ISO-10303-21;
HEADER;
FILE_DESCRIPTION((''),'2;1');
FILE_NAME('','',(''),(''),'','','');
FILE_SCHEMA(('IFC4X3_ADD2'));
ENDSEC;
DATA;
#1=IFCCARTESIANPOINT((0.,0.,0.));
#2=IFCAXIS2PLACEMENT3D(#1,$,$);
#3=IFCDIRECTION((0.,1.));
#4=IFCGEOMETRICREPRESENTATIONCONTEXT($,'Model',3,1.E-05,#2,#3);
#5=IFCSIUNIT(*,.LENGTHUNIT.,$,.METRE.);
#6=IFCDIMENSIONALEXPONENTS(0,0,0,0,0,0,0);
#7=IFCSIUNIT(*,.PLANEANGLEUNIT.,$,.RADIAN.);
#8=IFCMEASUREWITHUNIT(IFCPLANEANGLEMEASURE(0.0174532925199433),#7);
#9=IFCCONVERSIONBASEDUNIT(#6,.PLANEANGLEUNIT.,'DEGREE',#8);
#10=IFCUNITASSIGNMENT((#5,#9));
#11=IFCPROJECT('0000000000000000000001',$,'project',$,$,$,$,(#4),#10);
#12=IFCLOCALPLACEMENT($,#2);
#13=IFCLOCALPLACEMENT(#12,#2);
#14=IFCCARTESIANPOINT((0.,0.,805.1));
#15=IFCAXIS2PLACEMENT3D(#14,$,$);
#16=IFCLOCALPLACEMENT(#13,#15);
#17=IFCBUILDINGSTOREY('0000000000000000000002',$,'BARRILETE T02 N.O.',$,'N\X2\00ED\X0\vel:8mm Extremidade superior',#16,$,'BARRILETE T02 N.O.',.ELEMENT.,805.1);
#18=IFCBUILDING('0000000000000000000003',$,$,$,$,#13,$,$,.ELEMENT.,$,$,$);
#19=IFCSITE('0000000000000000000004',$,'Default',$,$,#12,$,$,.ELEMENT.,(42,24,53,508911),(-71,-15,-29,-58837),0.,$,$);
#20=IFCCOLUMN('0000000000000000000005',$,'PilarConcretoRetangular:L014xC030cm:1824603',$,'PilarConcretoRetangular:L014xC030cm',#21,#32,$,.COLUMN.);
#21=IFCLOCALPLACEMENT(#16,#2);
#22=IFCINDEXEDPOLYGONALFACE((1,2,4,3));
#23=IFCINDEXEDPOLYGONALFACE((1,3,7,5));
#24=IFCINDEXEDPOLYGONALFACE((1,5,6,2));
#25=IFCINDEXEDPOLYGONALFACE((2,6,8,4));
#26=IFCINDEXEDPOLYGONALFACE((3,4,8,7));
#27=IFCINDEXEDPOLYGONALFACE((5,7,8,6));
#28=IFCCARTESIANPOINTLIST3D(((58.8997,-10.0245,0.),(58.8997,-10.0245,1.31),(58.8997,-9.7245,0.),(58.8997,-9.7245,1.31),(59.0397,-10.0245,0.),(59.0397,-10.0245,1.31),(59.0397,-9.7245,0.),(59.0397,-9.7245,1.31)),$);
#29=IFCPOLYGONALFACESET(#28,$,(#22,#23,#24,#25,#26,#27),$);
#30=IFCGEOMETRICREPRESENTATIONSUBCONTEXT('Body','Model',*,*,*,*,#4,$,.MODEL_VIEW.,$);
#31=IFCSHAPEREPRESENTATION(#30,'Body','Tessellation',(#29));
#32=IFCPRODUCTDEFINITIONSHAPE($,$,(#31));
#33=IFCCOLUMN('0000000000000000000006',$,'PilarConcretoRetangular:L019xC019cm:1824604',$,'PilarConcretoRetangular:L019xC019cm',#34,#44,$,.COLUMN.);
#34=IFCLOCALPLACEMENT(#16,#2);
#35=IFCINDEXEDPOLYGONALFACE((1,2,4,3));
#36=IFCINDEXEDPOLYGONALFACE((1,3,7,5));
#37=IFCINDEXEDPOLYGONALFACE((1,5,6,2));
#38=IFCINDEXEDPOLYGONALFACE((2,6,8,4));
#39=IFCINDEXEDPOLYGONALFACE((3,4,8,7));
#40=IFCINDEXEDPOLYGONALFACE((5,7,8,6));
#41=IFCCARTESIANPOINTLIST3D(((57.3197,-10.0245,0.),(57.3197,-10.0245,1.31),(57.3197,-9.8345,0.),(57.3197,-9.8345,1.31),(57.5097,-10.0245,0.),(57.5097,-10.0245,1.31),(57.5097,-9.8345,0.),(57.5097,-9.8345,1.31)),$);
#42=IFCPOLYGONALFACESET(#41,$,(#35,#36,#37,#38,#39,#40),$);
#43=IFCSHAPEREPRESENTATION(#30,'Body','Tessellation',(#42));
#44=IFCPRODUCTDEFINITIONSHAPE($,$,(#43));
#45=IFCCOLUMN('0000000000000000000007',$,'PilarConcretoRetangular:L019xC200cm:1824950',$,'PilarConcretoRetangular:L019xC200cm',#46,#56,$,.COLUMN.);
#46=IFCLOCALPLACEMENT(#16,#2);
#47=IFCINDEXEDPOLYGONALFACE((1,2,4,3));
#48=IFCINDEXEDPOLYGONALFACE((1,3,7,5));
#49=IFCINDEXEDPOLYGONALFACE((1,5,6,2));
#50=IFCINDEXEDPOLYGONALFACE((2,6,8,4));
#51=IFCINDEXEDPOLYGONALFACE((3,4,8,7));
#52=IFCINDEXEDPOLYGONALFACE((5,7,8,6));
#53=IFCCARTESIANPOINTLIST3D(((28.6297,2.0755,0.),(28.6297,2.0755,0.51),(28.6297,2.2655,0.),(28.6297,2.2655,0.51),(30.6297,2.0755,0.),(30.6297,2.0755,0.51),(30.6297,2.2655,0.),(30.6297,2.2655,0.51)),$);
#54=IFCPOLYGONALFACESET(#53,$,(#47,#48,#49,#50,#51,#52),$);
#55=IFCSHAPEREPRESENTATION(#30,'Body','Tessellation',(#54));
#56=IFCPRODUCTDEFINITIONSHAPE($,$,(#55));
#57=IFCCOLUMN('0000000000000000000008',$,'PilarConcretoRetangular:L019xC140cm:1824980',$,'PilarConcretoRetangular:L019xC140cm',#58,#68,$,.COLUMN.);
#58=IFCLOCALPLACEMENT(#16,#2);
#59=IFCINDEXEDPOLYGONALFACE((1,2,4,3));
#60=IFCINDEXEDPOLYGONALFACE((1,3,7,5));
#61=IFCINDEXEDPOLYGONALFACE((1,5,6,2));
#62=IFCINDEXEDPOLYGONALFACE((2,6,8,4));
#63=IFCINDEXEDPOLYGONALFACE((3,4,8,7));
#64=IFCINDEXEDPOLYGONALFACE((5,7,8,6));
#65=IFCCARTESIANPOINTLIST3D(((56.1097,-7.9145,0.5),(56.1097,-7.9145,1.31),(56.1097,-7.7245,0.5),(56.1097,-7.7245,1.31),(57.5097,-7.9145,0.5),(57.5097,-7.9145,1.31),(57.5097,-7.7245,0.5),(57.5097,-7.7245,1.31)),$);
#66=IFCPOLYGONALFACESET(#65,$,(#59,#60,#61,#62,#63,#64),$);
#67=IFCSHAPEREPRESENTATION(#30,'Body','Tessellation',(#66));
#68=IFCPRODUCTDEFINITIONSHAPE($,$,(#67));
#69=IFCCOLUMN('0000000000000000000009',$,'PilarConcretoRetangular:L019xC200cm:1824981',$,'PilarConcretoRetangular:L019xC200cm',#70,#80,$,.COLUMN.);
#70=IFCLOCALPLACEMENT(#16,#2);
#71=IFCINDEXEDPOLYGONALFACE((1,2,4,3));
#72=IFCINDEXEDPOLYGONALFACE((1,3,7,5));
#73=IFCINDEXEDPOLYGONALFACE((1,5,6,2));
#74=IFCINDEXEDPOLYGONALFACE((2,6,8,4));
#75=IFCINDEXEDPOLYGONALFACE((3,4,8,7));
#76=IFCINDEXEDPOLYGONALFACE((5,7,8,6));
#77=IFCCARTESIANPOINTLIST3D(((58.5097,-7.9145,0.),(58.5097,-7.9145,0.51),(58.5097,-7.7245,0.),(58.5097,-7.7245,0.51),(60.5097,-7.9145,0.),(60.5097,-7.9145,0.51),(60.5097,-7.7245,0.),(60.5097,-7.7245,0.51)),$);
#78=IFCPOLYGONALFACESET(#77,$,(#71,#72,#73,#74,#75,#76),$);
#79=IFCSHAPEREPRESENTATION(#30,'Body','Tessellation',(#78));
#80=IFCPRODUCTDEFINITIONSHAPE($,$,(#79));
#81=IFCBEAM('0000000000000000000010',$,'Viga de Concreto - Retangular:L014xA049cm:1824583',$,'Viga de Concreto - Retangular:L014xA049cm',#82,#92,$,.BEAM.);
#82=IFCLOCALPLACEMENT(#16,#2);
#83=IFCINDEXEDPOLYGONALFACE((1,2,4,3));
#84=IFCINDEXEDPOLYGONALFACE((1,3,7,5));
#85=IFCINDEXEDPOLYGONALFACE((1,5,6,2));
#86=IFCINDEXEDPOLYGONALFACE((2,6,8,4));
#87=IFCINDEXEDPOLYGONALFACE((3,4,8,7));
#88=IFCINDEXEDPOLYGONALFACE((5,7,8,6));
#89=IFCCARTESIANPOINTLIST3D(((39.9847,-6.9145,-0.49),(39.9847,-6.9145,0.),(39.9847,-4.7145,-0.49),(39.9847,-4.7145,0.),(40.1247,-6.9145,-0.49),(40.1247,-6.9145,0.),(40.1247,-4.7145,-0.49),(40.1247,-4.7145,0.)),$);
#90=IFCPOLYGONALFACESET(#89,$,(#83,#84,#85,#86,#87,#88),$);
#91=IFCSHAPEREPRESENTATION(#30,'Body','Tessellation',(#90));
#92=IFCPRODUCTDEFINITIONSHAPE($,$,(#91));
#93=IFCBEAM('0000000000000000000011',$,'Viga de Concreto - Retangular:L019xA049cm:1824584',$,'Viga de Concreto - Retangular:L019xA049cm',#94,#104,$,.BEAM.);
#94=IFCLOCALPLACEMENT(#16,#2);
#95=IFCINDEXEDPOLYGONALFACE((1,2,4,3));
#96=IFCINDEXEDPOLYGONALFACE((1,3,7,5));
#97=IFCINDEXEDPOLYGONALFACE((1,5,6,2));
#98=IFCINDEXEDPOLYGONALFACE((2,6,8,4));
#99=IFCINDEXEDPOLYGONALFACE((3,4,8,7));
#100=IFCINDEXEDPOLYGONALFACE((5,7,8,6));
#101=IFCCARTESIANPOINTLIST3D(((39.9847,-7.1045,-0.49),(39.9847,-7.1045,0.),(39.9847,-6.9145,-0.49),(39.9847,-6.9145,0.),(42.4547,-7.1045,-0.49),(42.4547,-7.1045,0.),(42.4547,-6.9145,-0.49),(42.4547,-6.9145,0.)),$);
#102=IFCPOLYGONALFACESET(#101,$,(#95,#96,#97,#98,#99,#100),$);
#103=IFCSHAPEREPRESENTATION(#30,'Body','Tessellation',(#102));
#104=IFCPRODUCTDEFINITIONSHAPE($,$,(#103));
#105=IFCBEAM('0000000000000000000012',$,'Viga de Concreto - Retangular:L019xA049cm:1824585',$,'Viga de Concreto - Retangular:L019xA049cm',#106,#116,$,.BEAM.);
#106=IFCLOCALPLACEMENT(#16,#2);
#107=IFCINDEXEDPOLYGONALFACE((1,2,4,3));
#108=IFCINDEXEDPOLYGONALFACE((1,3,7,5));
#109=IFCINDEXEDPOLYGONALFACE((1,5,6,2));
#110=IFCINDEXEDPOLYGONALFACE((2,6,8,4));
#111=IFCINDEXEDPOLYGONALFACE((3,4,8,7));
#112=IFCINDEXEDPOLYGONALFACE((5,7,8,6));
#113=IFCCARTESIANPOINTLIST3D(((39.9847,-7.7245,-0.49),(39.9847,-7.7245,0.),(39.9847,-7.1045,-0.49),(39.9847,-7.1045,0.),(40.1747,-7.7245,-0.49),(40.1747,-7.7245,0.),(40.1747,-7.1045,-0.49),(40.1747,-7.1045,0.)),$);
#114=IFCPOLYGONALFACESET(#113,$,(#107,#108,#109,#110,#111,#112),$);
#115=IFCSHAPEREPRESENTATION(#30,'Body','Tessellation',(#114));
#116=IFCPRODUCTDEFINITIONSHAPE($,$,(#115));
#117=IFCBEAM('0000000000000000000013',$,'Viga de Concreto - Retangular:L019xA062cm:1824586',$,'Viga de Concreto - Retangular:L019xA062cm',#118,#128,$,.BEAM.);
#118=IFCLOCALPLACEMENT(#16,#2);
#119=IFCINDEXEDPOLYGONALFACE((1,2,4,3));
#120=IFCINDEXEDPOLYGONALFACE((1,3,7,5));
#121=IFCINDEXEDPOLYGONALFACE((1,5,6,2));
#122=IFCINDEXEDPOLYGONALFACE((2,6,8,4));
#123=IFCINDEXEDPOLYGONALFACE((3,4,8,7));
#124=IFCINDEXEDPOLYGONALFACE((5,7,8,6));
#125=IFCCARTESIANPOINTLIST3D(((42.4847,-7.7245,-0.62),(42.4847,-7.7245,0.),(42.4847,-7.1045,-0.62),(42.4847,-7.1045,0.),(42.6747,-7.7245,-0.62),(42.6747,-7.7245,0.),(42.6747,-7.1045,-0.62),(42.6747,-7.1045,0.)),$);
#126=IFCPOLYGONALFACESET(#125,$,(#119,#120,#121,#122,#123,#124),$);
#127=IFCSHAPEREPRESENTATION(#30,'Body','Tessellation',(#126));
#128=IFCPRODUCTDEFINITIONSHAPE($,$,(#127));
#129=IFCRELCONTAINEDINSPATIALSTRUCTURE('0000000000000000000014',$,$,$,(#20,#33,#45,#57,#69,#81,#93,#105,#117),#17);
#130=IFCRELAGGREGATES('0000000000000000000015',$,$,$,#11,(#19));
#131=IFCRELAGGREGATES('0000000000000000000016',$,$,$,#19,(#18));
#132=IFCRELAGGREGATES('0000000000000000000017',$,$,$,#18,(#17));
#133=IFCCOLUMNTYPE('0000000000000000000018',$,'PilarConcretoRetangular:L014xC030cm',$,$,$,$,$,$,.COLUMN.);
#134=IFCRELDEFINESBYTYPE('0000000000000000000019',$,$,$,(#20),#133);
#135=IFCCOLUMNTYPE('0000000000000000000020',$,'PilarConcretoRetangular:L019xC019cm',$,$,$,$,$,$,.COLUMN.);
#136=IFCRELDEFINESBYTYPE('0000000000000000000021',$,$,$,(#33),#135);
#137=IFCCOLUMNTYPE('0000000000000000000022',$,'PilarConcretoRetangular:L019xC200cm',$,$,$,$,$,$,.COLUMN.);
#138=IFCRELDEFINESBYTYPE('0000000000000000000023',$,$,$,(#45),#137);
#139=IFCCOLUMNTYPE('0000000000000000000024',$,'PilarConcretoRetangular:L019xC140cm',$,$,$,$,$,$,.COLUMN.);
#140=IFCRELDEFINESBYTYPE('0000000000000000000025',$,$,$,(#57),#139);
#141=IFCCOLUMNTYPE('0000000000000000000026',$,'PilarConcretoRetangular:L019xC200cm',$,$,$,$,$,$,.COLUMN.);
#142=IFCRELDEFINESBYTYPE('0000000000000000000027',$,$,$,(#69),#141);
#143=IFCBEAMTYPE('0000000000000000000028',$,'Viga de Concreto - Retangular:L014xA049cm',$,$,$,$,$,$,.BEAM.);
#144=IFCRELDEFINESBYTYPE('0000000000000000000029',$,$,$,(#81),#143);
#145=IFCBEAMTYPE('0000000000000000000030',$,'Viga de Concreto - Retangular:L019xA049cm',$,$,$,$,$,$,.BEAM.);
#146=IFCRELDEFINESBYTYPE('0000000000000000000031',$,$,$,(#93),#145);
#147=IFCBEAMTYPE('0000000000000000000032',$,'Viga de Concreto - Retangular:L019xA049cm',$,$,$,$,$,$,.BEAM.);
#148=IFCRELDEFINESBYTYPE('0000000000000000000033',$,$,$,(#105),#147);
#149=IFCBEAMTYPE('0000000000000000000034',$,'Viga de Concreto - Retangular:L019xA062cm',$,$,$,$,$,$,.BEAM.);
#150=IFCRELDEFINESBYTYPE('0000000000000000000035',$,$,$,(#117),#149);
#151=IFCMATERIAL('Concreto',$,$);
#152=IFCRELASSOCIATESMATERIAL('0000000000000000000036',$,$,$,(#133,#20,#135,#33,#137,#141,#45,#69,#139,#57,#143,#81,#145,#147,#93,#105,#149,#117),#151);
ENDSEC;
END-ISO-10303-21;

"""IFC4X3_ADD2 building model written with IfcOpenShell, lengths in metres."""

from ifc_helpers import new_model, entity, si_unit, converted_unit, direction, frame, frame_2d, origin, origin_2d_with_axis, place, context, subcontext, project, spatial, rectangle, extrude, source, transform, mapped, material, material_profile, profile_set, profile_usage, type_object, type_shapes, element, save


model = new_model("IFC4X3_ADD2")

# Units and contexts
model_context = context("Model", 3, precision=1e-05, world=origin(), true_north=direction((0.0, 1.0)))
body_context = subcontext(model_context, "Body", "Model", "MODEL_VIEW")
ifc_project = project(units=[si_unit("LENGTHUNIT", "METRE"), converted_unit("PLANEANGLEUNIT", "DEGREE", entity("IfcPlaneAngleMeasure", 0.0174532925199433), si_unit("PLANEANGLEUNIT", "RADIAN"), dimensions=[0, 0, 0, 0, 0, 0, 0])], contexts=[model_context])

# Site, building, storey
site_placement = place(None, origin())
site = spatial("IfcSite", under=ifc_project, at=site_placement, Name="Default", CompositionType="ELEMENT", RefLatitude=(42, 24, 53, 508911), RefLongitude=(-71, -15, -29, -58837), RefElevation=0.0)
building_placement = place(site_placement, origin())
building = spatial("IfcBuilding", under=site, at=building_placement, CompositionType="ELEMENT")
storey_placement = place(building_placement, frame((0.0, 0.0, 805.1)))
storey = spatial("IfcBuildingStorey", under=building, at=storey_placement, Name="BARRILETE T02 N.O.", ObjectType="Nível:8mm Extremidade superior", LongName="BARRILETE T02 N.O.", CompositionType="ELEMENT", Elevation=805.1)

# Columns
ifc_material = material(Name="Concreto")
ifc_material_profile_1 = material_profile(ifc_material, rectangle(XDim=0.14, YDim=0.3, at=frame_2d((0.0, 0.0), x_axis=(1.0, 0.0))), Name="L014xC030cm")
ifc_profile_set_1 = profile_set([ifc_material_profile_1], Name="L014xC030cm")
ifc_profile_usage_1 = profile_usage(ifc_profile_set_1)
column_type_1 = type_object("IfcColumnType", Name="PilarConcretoRetangular:L014xC030cm", PredefinedType="COLUMN", material=ifc_profile_set_1)
shared_shape_1 = source(origin(), body_context, "Body", "SweptSolid", [
    extrude(rectangle(XDim=0.14, YDim=0.3, at=frame_2d((0.0, 0.0), x_axis=(1.0, 0.0))), frame((58.9697, -9.8745, 805.1), z_axis=(0.0, 0.0, 1.0), x_axis=(-1.0, 0.0, 0.0)), (0.0, 0.0, 1.0), 1.31),
])
type_shapes(column_type_1, [shared_shape_1])
column_1_placement = place(storey_placement, frame((0.0, 0.0, -805.1)))
element("IfcColumn", 1, at=column_1_placement, inside=storey, type_object=column_type_1, material=ifc_profile_usage_1, Name="PilarConcretoRetangular:L014xC030cm:1824603", ObjectType="PilarConcretoRetangular:L014xC030cm", PredefinedType="COLUMN", context=body_context, shape_type="MappedRepresentation", body=[
    mapped(shared_shape_1, transform((0.0, 0.0, 0.0), scale=1.0)),
])
ifc_material_profile_2 = material_profile(ifc_material, rectangle(XDim=0.19, YDim=0.19, at=frame_2d((0.0, 0.0), x_axis=(1.0, 0.0))), Name="L019xC019cm")
ifc_profile_set_2 = profile_set([ifc_material_profile_2], Name="L019xC019cm")
ifc_profile_usage_2 = profile_usage(ifc_profile_set_2)
column_type_2 = type_object("IfcColumnType", Name="PilarConcretoRetangular:L019xC019cm", PredefinedType="COLUMN", material=ifc_profile_set_2)
shared_shape_2 = source(origin(), body_context, "Body", "SweptSolid", [
    extrude(rectangle(XDim=0.19, YDim=0.19, at=frame_2d((0.0, 0.0), x_axis=(1.0, 0.0))), frame((57.4147, -9.9295, 805.1), z_axis=(0.0, 0.0, 1.0), x_axis=(0.0, 1.0, 0.0)), (0.0, 0.0, 1.0), 1.31),
])
type_shapes(column_type_2, [shared_shape_2])
column_2_placement = place(storey_placement, frame((0.0, 0.0, -805.1)))
element("IfcColumn", 2, at=column_2_placement, inside=storey, type_object=column_type_2, material=ifc_profile_usage_2, Name="PilarConcretoRetangular:L019xC019cm:1824604", ObjectType="PilarConcretoRetangular:L019xC019cm", PredefinedType="COLUMN", context=body_context, shape_type="MappedRepresentation", body=[
    mapped(shared_shape_2, transform((0.0, 0.0, 0.0), scale=1.0)),
])
ifc_material_profile_3 = material_profile(ifc_material, rectangle(XDim=0.19, YDim=2.0, at=frame_2d((0.0, 0.0), x_axis=(1.0, 0.0))), Name="L019xC200cm")
ifc_profile_set_3 = profile_set([ifc_material_profile_3], Name="L019xC200cm")
ifc_profile_usage_3 = profile_usage(ifc_profile_set_3)
column_type_3 = type_object("IfcColumnType", Name="PilarConcretoRetangular:L019xC200cm", PredefinedType="COLUMN", material=ifc_profile_set_3)
shared_shape_3 = source(origin(), body_context, "Body", "SweptSolid", [
    extrude(rectangle(XDim=0.19, YDim=2.0, at=frame_2d((0.0, 0.0), x_axis=(1.0, 0.0))), frame((29.6297, 2.1705, 805.1), z_axis=(0.0, 0.0, 1.0), x_axis=(0.0, 1.0, 0.0)), (0.0, 0.0, 1.0), 0.51),
])
type_shapes(column_type_3, [shared_shape_3])
column_3_placement = place(storey_placement, frame((0.0, 0.0, -805.1)))
element("IfcColumn", 3, at=column_3_placement, inside=storey, type_object=column_type_3, material=ifc_profile_usage_3, Name="PilarConcretoRetangular:L019xC200cm:1824950", ObjectType="PilarConcretoRetangular:L019xC200cm", PredefinedType="COLUMN", context=body_context, shape_type="MappedRepresentation", body=[
    mapped(shared_shape_3, transform((0.0, 0.0, 0.0), scale=1.0)),
])
ifc_material_profile_4 = material_profile(ifc_material, rectangle(XDim=0.19, YDim=1.4, at=origin_2d_with_axis()), Name="L019xC140cm")
ifc_profile_set_4 = profile_set([ifc_material_profile_4], Name="L019xC140cm")
ifc_profile_usage_4 = profile_usage(ifc_profile_set_4)
column_type_4 = type_object("IfcColumnType", Name="PilarConcretoRetangular:L019xC140cm", PredefinedType="COLUMN", material=ifc_profile_set_4)
shared_shape_4 = source(origin(), body_context, "Body", "SweptSolid", [
    extrude(rectangle(XDim=0.19, YDim=1.4, at=origin_2d_with_axis()), frame((56.8097, -7.8195, 805.6), z_axis=(0.0, 0.0, 1.0), x_axis=(0.0, -1.0, 0.0)), (0.0, 0.0, 1.0), 0.81),
])
type_shapes(column_type_4, [shared_shape_4])
column_4_placement = place(storey_placement, frame((0.0, 0.0, -805.1)))
element("IfcColumn", 4, at=column_4_placement, inside=storey, type_object=column_type_4, material=ifc_profile_usage_4, Name="PilarConcretoRetangular:L019xC140cm:1824980", ObjectType="PilarConcretoRetangular:L019xC140cm", PredefinedType="COLUMN", context=body_context, shape_type="MappedRepresentation", body=[
    mapped(shared_shape_4, transform((0.0, 0.0, 0.0), scale=1.0)),
])
column_type_5 = type_object("IfcColumnType", Name="PilarConcretoRetangular:L019xC200cm", PredefinedType="COLUMN", material=ifc_profile_set_3)
shared_shape_5 = source(origin(), body_context, "Body", "SweptSolid", [
    extrude(rectangle(XDim=2.0, YDim=0.19, at=frame_2d((0.0, 0.0), x_axis=(1.0, 0.0))), frame((59.5097, -7.8195, 805.1), z_axis=(0.0, 0.0, 1.0), x_axis=(-1.0, 0.0, 0.0)), (0.0, 0.0, 1.0), 0.51),
])
type_shapes(column_type_5, [shared_shape_5])
column_5_placement = place(storey_placement, frame((0.0, 0.0, -805.1)))
element("IfcColumn", 5, at=column_5_placement, inside=storey, type_object=column_type_5, material=ifc_profile_usage_3, Name="PilarConcretoRetangular:L019xC200cm:1824981", ObjectType="PilarConcretoRetangular:L019xC200cm", PredefinedType="COLUMN", context=body_context, shape_type="MappedRepresentation", body=[
    mapped(shared_shape_5, transform((0.0, 0.0, 0.0), scale=1.0)),
])

# Beams
ifc_material_profile_5 = material_profile(ifc_material, rectangle(XDim=0.62, YDim=0.19, at=frame_2d((0.0, 0.0), x_axis=(0.0, 1.0))), Name="L019xA062cm")
ifc_profile_set_5 = profile_set([ifc_material_profile_5], Name="L019xA062cm")
ifc_material_profile_6 = material_profile(ifc_material, rectangle(XDim=0.49, YDim=0.14, at=frame_2d((0.0, 0.0), x_axis=(0.0, 1.0))), Name="L014xA049cm")
ifc_profile_set_6 = profile_set([ifc_material_profile_6], Name="L014xA049cm")
ifc_profile_usage_5 = profile_usage(ifc_profile_set_6, cardinal=8)
beam_type_1 = type_object("IfcBeamType", Name="Viga de Concreto - Retangular:L014xA049cm", PredefinedType="BEAM", material=ifc_profile_set_6)
shared_shape_6 = source(origin(), body_context, "Body", "SweptSolid", [
    extrude(rectangle(XDim=0.49, YDim=0.14, at=frame_2d((0.0, 0.0), x_axis=(0.0, 1.0))), frame((40.0547, -4.7145, 804.855), z_axis=(0.0, -1.0, 0.0), x_axis=(-1.0, 0.0, 0.0)), (0.0, 0.0, 1.0), 2.2),
])
type_shapes(beam_type_1, [shared_shape_6])
beam_1_placement = place(storey_placement, frame((0.0, 0.0, -805.1)))
element("IfcBeam", 6, at=beam_1_placement, inside=storey, type_object=beam_type_1, material=ifc_profile_usage_5, Name="Viga de Concreto - Retangular:L014xA049cm:1824583", ObjectType="Viga de Concreto - Retangular:L014xA049cm", PredefinedType="BEAM", context=body_context, shape_type="MappedRepresentation", body=[
    mapped(shared_shape_6, transform((0.0, 0.0, 0.0), scale=1.0)),
])
ifc_material_profile_7 = material_profile(ifc_material, rectangle(XDim=0.49, YDim=0.19, at=frame_2d((0.0, 0.0), x_axis=(1.0, 0.0))), Name="L019xA049cm")
ifc_profile_set_7 = profile_set([ifc_material_profile_7], Name="L019xA049cm")
ifc_profile_usage_6 = profile_usage(ifc_profile_set_7, cardinal=8)
beam_type_2 = type_object("IfcBeamType", Name="Viga de Concreto - Retangular:L019xA049cm", PredefinedType="BEAM", material=ifc_profile_set_7)
shared_shape_7 = source(origin(), body_context, "Body", "SweptSolid", [
    extrude(rectangle(XDim=0.49, YDim=0.19, at=frame_2d((0.0, 0.0), x_axis=(1.0, 0.0))), frame((42.4547, -7.0095, 804.855), z_axis=(-1.0, 0.0, 0.0), x_axis=(0.0, 0.0, -1.0)), (0.0, 0.0, 1.0), 2.47),
])
type_shapes(beam_type_2, [shared_shape_7])
beam_2_placement = place(storey_placement, frame((0.0, 0.0, -805.1)))
element("IfcBeam", 7, at=beam_2_placement, inside=storey, type_object=beam_type_2, material=ifc_profile_usage_6, Name="Viga de Concreto - Retangular:L019xA049cm:1824584", ObjectType="Viga de Concreto - Retangular:L019xA049cm", PredefinedType="BEAM", context=body_context, shape_type="MappedRepresentation", body=[
    mapped(shared_shape_7, transform((0.0, 0.0, 0.0), scale=1.0)),
])
beam_type_3 = type_object("IfcBeamType", Name="Viga de Concreto - Retangular:L019xA049cm", PredefinedType="BEAM", material=ifc_profile_set_7)
shared_shape_8 = source(origin(), body_context, "Body", "SweptSolid", [
    extrude(rectangle(XDim=0.49, YDim=0.19, at=frame_2d((0.0, 0.0), x_axis=(0.0, 1.0))), frame((40.0797, -7.7245, 804.855), z_axis=(0.0, 1.0, 0.0), x_axis=(-1.0, 0.0, 0.0)), (0.0, 0.0, 1.0), 0.62),
])
type_shapes(beam_type_3, [shared_shape_8])
beam_3_placement = place(storey_placement, frame((0.0, 0.0, -805.1)))
element("IfcBeam", 8, at=beam_3_placement, inside=storey, type_object=beam_type_3, material=ifc_profile_usage_6, Name="Viga de Concreto - Retangular:L019xA049cm:1824585", ObjectType="Viga de Concreto - Retangular:L019xA049cm", PredefinedType="BEAM", context=body_context, shape_type="MappedRepresentation", body=[
    mapped(shared_shape_8, transform((0.0, 0.0, 0.0), scale=1.0)),
])
ifc_profile_usage_7 = profile_usage(ifc_profile_set_5, cardinal=8)
beam_type_4 = type_object("IfcBeamType", Name="Viga de Concreto - Retangular:L019xA062cm", PredefinedType="BEAM", material=ifc_profile_set_5)
shared_shape_9 = source(origin(), body_context, "Body", "SweptSolid", [
    extrude(rectangle(XDim=0.62, YDim=0.19, at=frame_2d((0.0, 0.0), x_axis=(0.0, 1.0))), frame((42.5797, -7.1045, 804.79), z_axis=(0.0, -1.0, 0.0), x_axis=(-1.0, 0.0, 0.0)), (0.0, 0.0, 1.0), 0.62),
])
type_shapes(beam_type_4, [shared_shape_9])
beam_4_placement = place(storey_placement, frame((0.0, 0.0, -805.1)))
element("IfcBeam", 9, at=beam_4_placement, inside=storey, type_object=beam_type_4, material=ifc_profile_usage_7, Name="Viga de Concreto - Retangular:L019xA062cm:1824586", ObjectType="Viga de Concreto - Retangular:L019xA062cm", PredefinedType="BEAM", context=body_context, shape_type="MappedRepresentation", body=[
    mapped(shared_shape_9, transform((0.0, 0.0, 0.0), scale=1.0)),
])

save(model, "model.ifc")
